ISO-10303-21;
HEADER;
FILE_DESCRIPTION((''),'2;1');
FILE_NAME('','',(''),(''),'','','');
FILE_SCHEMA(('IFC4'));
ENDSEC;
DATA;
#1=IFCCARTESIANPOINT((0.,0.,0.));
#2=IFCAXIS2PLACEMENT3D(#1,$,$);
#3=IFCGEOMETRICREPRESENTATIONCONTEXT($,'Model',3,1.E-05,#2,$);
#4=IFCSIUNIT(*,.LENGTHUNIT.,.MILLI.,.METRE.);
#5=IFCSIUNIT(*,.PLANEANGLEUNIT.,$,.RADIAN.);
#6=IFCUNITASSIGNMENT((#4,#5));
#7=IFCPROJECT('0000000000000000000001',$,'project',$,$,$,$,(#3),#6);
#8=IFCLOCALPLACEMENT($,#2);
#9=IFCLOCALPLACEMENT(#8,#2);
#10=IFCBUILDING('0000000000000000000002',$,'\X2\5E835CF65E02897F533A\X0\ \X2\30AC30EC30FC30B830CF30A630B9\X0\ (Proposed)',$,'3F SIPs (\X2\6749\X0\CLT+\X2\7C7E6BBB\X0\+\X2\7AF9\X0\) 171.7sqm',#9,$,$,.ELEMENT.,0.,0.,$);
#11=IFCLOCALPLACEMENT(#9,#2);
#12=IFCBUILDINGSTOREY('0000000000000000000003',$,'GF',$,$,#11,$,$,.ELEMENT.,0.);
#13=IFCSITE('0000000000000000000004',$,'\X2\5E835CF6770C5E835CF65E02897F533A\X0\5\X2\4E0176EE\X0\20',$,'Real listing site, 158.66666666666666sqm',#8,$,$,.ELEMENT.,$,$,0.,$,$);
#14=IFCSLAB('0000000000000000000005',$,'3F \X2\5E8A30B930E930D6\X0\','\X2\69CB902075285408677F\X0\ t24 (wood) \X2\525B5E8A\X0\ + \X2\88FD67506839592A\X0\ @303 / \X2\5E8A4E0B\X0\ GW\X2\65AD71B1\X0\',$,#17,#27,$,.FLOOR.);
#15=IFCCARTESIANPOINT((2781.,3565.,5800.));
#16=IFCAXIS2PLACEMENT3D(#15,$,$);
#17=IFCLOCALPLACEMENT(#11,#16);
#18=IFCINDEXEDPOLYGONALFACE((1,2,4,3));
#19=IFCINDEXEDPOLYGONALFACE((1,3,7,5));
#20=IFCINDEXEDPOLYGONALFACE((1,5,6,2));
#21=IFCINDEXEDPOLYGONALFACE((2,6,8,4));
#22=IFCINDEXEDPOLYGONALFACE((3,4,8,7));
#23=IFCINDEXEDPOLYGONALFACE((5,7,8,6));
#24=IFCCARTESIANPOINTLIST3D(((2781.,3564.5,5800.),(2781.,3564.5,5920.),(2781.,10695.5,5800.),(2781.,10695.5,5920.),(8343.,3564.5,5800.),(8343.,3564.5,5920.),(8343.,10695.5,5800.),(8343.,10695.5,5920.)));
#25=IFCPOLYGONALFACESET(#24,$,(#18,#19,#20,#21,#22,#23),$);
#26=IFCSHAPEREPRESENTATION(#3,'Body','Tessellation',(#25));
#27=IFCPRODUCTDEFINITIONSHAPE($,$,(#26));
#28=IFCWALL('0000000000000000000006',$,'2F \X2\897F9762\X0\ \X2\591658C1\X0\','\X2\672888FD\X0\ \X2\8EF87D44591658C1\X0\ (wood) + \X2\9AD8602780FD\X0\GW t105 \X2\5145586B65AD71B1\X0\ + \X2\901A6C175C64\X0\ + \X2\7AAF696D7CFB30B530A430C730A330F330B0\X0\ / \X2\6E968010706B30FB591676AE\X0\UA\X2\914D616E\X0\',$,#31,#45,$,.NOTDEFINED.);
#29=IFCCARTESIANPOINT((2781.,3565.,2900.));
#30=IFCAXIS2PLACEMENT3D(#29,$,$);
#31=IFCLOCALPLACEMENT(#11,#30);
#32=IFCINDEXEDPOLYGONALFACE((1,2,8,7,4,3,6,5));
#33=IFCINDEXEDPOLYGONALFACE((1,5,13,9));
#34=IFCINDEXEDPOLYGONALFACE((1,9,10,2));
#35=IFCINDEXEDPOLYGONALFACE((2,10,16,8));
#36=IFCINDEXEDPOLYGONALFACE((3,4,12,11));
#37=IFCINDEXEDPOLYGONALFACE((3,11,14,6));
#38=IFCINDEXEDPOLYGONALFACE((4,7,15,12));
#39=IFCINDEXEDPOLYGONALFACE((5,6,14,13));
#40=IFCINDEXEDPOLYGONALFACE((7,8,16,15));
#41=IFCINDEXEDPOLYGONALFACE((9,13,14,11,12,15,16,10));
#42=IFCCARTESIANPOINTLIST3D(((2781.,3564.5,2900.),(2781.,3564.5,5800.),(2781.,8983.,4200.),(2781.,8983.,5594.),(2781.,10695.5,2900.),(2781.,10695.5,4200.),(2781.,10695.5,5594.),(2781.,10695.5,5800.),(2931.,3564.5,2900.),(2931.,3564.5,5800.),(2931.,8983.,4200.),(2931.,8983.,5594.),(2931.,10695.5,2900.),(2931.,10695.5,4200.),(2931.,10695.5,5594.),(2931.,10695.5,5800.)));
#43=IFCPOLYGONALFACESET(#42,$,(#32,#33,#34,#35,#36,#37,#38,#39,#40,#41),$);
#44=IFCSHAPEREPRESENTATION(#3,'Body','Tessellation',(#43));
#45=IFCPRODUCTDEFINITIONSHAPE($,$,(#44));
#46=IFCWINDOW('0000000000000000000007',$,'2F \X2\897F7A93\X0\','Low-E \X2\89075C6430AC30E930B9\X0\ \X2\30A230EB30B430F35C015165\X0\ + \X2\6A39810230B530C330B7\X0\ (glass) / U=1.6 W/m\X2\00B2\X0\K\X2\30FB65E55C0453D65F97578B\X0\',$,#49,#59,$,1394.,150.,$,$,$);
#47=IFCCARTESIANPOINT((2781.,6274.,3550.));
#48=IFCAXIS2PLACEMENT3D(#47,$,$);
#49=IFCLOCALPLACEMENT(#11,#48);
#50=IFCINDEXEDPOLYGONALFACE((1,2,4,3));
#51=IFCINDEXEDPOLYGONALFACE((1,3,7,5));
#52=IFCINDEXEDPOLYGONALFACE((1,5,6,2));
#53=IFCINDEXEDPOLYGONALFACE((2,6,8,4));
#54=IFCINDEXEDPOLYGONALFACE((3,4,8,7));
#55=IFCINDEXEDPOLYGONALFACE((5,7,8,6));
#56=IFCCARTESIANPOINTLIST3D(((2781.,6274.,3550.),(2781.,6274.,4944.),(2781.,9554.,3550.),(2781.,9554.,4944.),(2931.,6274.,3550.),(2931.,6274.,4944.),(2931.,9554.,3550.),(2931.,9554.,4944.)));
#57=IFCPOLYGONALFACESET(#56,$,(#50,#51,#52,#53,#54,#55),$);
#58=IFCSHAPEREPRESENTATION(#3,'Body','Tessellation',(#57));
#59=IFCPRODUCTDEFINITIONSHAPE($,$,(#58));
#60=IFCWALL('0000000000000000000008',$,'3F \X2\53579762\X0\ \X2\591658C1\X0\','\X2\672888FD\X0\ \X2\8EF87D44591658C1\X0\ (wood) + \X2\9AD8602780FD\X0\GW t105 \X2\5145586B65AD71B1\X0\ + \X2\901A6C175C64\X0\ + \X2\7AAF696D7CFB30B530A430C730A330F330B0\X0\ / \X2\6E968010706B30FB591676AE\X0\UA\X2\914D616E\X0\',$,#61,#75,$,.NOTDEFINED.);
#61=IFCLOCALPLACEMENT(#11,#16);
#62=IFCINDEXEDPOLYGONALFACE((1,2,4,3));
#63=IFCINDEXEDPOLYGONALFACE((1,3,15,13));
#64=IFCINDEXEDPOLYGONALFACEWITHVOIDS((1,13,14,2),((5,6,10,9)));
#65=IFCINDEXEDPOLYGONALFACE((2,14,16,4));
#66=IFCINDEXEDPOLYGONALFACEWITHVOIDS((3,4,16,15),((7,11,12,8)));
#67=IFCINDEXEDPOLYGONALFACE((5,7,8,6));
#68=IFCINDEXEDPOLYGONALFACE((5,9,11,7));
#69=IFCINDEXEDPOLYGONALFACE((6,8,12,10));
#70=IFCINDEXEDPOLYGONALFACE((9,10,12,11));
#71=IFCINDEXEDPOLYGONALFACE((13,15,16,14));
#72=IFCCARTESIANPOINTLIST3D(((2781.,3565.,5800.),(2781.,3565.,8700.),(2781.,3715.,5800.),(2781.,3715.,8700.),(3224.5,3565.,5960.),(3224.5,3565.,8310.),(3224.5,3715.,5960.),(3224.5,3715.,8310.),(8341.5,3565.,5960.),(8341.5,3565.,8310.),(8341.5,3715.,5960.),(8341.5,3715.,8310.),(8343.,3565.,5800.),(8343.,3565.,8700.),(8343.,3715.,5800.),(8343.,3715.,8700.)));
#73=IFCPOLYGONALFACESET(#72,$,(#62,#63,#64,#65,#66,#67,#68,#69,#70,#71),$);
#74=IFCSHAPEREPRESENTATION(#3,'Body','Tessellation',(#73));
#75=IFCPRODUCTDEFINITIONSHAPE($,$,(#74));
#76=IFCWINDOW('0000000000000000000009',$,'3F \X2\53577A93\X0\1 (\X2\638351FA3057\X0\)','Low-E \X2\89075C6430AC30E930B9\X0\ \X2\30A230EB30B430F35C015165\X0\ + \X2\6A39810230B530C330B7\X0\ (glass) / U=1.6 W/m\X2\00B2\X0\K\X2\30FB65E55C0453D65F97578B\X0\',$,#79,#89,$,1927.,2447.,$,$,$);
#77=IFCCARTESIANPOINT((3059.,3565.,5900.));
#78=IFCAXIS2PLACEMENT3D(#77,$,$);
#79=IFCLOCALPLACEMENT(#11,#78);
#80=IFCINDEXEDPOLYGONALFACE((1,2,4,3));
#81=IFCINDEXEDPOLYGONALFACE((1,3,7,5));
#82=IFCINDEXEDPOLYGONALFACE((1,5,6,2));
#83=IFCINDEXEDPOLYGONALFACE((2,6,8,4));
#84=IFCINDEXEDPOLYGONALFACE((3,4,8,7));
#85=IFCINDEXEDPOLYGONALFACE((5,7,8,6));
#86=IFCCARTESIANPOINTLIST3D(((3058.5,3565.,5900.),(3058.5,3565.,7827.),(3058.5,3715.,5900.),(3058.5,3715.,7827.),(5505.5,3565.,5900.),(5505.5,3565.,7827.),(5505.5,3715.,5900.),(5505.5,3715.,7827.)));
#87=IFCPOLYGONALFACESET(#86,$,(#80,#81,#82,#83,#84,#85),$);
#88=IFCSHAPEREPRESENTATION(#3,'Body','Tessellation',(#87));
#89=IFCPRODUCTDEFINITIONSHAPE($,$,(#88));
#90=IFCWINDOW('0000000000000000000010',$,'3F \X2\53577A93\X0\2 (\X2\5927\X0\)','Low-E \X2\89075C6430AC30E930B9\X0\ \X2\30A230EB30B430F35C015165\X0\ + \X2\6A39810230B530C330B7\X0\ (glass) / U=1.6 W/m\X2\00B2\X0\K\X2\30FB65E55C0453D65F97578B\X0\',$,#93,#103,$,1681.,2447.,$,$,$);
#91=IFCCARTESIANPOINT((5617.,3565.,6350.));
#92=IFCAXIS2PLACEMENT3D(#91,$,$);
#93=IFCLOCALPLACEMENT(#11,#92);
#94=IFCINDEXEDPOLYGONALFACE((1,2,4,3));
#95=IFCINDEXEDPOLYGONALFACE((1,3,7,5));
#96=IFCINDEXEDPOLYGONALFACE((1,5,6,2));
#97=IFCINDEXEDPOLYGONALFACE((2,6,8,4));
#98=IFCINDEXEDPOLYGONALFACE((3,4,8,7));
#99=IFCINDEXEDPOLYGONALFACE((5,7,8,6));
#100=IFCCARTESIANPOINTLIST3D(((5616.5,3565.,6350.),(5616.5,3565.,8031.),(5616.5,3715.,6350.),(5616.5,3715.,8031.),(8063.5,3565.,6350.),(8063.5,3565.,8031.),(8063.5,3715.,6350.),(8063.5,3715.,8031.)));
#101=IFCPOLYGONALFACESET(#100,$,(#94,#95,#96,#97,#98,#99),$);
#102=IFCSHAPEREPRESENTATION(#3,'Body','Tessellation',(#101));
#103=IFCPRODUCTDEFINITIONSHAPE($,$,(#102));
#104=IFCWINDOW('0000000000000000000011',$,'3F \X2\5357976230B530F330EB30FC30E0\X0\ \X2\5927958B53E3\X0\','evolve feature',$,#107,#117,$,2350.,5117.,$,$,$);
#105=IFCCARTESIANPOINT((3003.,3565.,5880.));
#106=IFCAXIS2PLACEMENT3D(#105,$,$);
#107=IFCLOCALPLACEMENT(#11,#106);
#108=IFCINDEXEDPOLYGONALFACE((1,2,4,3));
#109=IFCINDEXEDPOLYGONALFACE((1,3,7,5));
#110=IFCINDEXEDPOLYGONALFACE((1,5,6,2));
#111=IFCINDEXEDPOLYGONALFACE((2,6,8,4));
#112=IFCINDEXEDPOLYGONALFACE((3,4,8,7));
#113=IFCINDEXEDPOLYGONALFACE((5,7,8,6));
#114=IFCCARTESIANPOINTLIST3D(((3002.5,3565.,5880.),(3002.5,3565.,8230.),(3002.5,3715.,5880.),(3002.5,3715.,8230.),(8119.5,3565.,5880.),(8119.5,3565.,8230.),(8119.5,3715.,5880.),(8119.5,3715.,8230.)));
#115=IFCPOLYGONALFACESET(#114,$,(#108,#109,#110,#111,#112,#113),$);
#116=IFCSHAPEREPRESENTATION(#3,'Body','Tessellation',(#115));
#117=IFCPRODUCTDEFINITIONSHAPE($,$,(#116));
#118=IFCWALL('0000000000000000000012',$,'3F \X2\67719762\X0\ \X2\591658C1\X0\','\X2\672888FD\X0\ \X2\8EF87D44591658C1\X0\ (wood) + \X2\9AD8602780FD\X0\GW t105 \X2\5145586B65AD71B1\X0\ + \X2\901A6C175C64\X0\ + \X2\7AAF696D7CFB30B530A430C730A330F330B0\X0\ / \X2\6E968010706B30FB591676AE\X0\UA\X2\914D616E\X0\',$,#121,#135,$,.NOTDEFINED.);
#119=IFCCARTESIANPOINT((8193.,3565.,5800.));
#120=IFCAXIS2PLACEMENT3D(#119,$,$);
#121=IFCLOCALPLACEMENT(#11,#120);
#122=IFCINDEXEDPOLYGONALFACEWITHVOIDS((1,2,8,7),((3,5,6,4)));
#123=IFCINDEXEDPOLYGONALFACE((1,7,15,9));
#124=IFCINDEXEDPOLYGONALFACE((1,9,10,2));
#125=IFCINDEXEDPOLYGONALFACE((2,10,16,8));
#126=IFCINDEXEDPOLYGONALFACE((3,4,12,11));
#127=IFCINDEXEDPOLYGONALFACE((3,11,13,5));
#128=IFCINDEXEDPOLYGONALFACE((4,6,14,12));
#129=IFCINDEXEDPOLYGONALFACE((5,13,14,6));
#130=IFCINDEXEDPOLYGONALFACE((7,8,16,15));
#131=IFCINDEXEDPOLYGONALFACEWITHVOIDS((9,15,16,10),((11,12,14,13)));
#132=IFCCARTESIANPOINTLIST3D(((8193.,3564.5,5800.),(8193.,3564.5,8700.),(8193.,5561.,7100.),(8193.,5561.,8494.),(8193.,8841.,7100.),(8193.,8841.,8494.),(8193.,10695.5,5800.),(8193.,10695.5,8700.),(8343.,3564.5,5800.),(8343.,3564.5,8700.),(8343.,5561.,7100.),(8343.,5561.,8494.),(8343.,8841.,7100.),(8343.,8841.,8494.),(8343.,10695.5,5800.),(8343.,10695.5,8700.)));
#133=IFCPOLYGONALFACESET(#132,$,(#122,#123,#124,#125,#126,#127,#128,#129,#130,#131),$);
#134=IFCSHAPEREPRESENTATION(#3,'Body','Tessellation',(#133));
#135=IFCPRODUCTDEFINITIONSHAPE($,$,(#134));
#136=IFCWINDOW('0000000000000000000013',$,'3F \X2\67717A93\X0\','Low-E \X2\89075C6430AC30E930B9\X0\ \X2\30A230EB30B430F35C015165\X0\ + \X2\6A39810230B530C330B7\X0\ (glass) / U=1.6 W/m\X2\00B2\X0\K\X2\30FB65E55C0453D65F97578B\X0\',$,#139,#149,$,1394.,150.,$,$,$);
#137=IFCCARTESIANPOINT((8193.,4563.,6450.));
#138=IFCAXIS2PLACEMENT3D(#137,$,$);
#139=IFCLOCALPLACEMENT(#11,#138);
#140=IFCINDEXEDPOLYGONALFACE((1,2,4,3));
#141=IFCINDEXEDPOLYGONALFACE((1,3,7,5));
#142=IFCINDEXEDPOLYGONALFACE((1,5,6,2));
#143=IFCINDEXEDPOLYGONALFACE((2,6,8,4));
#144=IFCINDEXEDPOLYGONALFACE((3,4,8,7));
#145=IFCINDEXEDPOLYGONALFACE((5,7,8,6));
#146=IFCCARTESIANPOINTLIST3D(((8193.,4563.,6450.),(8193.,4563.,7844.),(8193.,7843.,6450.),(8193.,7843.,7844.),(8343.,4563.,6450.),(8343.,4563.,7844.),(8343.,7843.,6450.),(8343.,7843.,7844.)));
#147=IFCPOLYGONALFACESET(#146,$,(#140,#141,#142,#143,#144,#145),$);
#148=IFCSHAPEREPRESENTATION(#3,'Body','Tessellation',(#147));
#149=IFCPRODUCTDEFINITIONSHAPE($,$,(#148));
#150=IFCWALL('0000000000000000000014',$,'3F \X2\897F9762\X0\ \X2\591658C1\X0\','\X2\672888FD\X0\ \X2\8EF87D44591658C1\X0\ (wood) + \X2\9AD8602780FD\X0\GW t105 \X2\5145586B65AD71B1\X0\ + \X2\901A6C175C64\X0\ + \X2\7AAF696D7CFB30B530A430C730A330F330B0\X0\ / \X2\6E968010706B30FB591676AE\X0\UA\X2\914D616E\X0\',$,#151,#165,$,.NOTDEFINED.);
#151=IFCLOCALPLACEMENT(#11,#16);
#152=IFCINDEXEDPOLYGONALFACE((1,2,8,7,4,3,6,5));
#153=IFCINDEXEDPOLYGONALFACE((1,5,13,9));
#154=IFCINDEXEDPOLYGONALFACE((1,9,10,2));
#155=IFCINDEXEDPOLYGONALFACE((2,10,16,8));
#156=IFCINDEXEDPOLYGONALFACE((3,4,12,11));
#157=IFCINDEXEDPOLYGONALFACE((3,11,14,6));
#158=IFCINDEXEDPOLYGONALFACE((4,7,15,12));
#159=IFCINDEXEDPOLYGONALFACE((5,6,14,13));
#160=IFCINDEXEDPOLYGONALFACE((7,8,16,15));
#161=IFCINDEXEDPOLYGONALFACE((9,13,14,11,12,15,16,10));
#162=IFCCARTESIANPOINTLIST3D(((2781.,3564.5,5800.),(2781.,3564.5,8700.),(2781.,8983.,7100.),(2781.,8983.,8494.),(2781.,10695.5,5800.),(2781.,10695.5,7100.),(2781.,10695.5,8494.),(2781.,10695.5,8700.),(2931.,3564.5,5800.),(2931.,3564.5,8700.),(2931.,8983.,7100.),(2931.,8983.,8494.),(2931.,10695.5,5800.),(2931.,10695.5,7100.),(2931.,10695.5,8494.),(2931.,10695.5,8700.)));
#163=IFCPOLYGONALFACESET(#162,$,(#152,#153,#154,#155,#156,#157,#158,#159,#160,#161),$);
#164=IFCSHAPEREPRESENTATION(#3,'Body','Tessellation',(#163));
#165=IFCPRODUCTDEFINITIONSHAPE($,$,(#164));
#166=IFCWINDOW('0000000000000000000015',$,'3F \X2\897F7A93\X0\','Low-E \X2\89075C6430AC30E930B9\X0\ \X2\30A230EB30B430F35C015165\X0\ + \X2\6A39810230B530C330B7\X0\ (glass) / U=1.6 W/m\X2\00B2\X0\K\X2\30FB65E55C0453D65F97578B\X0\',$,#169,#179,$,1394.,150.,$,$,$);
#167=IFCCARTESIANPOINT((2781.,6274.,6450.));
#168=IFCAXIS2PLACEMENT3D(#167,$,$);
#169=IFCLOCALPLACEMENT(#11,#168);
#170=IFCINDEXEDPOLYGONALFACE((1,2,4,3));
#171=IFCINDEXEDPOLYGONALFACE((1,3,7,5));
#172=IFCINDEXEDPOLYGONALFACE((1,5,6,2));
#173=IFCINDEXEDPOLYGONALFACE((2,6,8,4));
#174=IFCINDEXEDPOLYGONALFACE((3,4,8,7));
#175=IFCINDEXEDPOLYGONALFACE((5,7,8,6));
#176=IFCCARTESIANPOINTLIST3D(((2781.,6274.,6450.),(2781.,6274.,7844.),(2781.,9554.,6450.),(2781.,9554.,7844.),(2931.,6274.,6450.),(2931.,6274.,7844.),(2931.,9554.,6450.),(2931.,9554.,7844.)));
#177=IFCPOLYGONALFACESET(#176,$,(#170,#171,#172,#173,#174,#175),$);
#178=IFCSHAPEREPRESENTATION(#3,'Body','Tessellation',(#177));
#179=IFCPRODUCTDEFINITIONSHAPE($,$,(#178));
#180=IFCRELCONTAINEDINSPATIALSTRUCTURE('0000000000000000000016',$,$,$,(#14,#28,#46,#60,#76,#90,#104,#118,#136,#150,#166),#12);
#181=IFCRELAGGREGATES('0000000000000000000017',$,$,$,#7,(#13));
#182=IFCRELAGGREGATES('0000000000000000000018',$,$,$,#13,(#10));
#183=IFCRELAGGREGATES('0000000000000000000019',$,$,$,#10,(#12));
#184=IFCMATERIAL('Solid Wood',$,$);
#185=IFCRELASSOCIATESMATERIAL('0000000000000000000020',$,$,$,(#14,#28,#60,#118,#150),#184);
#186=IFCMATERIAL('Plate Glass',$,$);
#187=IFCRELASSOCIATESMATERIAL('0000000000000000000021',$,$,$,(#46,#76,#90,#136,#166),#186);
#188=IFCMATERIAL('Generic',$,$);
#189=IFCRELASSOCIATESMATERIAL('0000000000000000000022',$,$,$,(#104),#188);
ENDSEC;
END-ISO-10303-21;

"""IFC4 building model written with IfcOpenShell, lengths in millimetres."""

from ifc_helpers import new_model, si_unit, frame, frame_2d, origin, place, context, project, spatial, rectangle, extrude, material, element, fill, save


model = new_model("IFC4")

# Units and contexts
model_context = context("Model", 3, precision=1e-05, world=origin())
ifc_project = project(units=[si_unit("LENGTHUNIT", "METRE", prefix="MILLI"), si_unit("PLANEANGLEUNIT", "RADIAN")], contexts=[model_context])

# Site, building, storey
site_placement = place(None, origin())
site = spatial("IfcSite", under=ifc_project, at=site_placement, Name="広島県広島市西区5丁目20", ObjectType="Real listing site, 158.66666666666666sqm", CompositionType="ELEMENT", RefElevation=0.0)
building_placement = place(site_placement, origin())
building = spatial("IfcBuilding", under=site, at=building_placement, Name="広島市西区 ガレージハウス (Proposed)", ObjectType="3F SIPs (杉CLT+籾殻+竹) 171.7sqm", CompositionType="ELEMENT", ElevationOfRefHeight=0.0, ElevationOfTerrain=0.0)
storey_placement = place(building_placement, origin())
storey = spatial("IfcBuildingStorey", under=building, at=storey_placement, Name="GF", CompositionType="ELEMENT", Elevation=0.0)

# Slab
ifc_material_1 = material(Name="Solid Wood")
slab_placement = place(storey_placement, frame((2781.0, 3565.0, 5800.0)))
element("IfcSlab", 1, at=slab_placement, inside=storey, material=ifc_material_1, Name="3F 床スラブ", Description="構造用合板 t24 (wood) 剛床 + 製材根太 @303 / 床下 GW断熱", PredefinedType="FLOOR", context=model_context, shape_type="SweptSolid", body=[
    extrude(rectangle(XDim=5562.0, YDim=7131.0, at=frame_2d((2781.0, 3565.0))), frame((2781.0, 3565.0, 5800.0)), (0.0, 0.0, 1.0), 120.0),
])

# Wall, opening, window
wall_1_placement = place(storey_placement, frame((2781.0, 3565.0, 2900.0)))
wall_1 = element("IfcWall", 2, at=wall_1_placement, inside=storey, material=ifc_material_1, Name="2F 西面 外壁", Description="木製 軸組外壁 (wood) + 高性能GW t105 充填断熱 + 通気層 + 窯業系サイディング / 準耐火・外皮UA配慮", PredefinedType="NOTDEFINED", context=model_context, shape_type="SweptSolid", body=[
    extrude(rectangle(XDim=150.0, YDim=7131.0, at=frame_2d((75.0, 3565.0))), frame((2781.0, 3565.0, 2900.0)), (0.0, 0.0, 1.0), 2900.0),
])
opening_1_placement = place(storey_placement, frame((2781.0, 6274.0, 3550.0)))
opening_1 = element("IfcOpeningElement", 3, at=opening_1_placement, cuts=wall_1, PredefinedType="NOTDEFINED", context=model_context, shape_type="SweptSolid", body=[
    extrude(rectangle(XDim=150.0, YDim=3280.0, at=frame_2d((75.0, 1640.0))), frame((2781.0, 6274.0, 3550.0)), (0.0, 0.0, 1.0), 1394.0),
])
ifc_material_2 = material(Name="Plate Glass")
window_1_placement = place(storey_placement, frame((2781.0, 6274.0, 3550.0)))
window_1 = element("IfcWindow", 4, at=window_1_placement, inside=storey, material=ifc_material_2, Name="2F 西窓", Description="Low-E 複層ガラス アルゴン封入 + 樹脂サッシ (glass) / U=1.6 W/m²K・日射取得型", OverallHeight=1394.0, OverallWidth=150.0, context=model_context, shape_type="SweptSolid", body=[
    extrude(rectangle(XDim=150.0, YDim=3280.0, at=frame_2d((75.0, 1640.0))), frame((2781.0, 6274.0, 3550.0)), (0.0, 0.0, 1.0), 1394.0),
])
fill(opening_1, window_1)

# Wall, openings, windows
wall_2_placement = place(storey_placement, frame((2781.0, 3565.0, 5800.0)))
wall_2 = element("IfcWall", 5, at=wall_2_placement, inside=storey, material=ifc_material_1, Name="3F 南面 外壁", Description="木製 軸組外壁 (wood) + 高性能GW t105 充填断熱 + 通気層 + 窯業系サイディング / 準耐火・外皮UA配慮", PredefinedType="NOTDEFINED", context=model_context, shape_type="SweptSolid", body=[
    extrude(rectangle(XDim=5562.0, YDim=150.0, at=frame_2d((2781.0, 75.0))), frame((2781.0, 3565.0, 5800.0)), (0.0, 0.0, 1.0), 2900.0),
])
opening_2_placement = place(storey_placement, frame((3059.0, 3565.0, 5900.0)))
opening_2 = element("IfcOpeningElement", 6, at=opening_2_placement, cuts=wall_2, PredefinedType="NOTDEFINED", context=model_context, shape_type="SweptSolid", body=[
    extrude(rectangle(XDim=2447.0, YDim=150.0, at=frame_2d((1223.0, 75.0))), frame((3059.0, 3565.0, 5900.0)), (0.0, 0.0, 1.0), 1927.0),
])
opening_3_placement = place(storey_placement, frame((5617.0, 3565.0, 6350.0)))
opening_3 = element("IfcOpeningElement", 7, at=opening_3_placement, cuts=wall_2, PredefinedType="NOTDEFINED", context=model_context, shape_type="SweptSolid", body=[
    extrude(rectangle(XDim=2447.0, YDim=150.0, at=frame_2d((1223.0, 75.0))), frame((5617.0, 3565.0, 6350.0)), (0.0, 0.0, 1.0), 1681.0),
])
opening_4_placement = place(storey_placement, frame((3003.0, 3565.0, 5880.0)))
opening_4 = element("IfcOpeningElement", 8, at=opening_4_placement, cuts=wall_2, PredefinedType="NOTDEFINED", context=model_context, shape_type="SweptSolid", body=[
    extrude(rectangle(XDim=5117.0, YDim=150.0, at=frame_2d((2558.0, 75.0))), frame((3003.0, 3565.0, 5880.0)), (0.0, 0.0, 1.0), 2350.0),
])
window_2_placement = place(storey_placement, frame((3059.0, 3565.0, 5900.0)))
window_2 = element("IfcWindow", 9, at=window_2_placement, inside=storey, material=ifc_material_2, Name="3F 南窓1 (掃出し)", Description="Low-E 複層ガラス アルゴン封入 + 樹脂サッシ (glass) / U=1.6 W/m²K・日射取得型", OverallHeight=1927.0, OverallWidth=2447.0, context=model_context, shape_type="SweptSolid", body=[
    extrude(rectangle(XDim=2447.0, YDim=150.0, at=frame_2d((1223.0, 75.0))), frame((3059.0, 3565.0, 5900.0)), (0.0, 0.0, 1.0), 1927.0),
])
fill(opening_2, window_2)
window_3_placement = place(storey_placement, frame((5617.0, 3565.0, 6350.0)))
window_3 = element("IfcWindow", 10, at=window_3_placement, inside=storey, material=ifc_material_2, Name="3F 南窓2 (大)", Description="Low-E 複層ガラス アルゴン封入 + 樹脂サッシ (glass) / U=1.6 W/m²K・日射取得型", OverallHeight=1681.0, OverallWidth=2447.0, context=model_context, shape_type="SweptSolid", body=[
    extrude(rectangle(XDim=2447.0, YDim=150.0, at=frame_2d((1223.0, 75.0))), frame((5617.0, 3565.0, 6350.0)), (0.0, 0.0, 1.0), 1681.0),
])
fill(opening_3, window_3)
ifc_material_3 = material(Name="Generic")
window_4_placement = place(storey_placement, frame((3003.0, 3565.0, 5880.0)))
window_4 = element("IfcWindow", 11, at=window_4_placement, inside=storey, material=ifc_material_3, Name="3F 南面サンルーム 大開口", Description="evolve feature", OverallHeight=2350.0, OverallWidth=5117.0, context=model_context, shape_type="SweptSolid", body=[
    extrude(rectangle(XDim=5117.0, YDim=150.0, at=frame_2d((2558.0, 75.0))), frame((3003.0, 3565.0, 5880.0)), (0.0, 0.0, 1.0), 2350.0),
])
fill(opening_4, window_4)

# Walls, openings, windows
wall_3_placement = place(storey_placement, frame((8193.0, 3565.0, 5800.0)))
wall_3 = element("IfcWall", 12, at=wall_3_placement, inside=storey, material=ifc_material_1, Name="3F 東面 外壁", Description="木製 軸組外壁 (wood) + 高性能GW t105 充填断熱 + 通気層 + 窯業系サイディング / 準耐火・外皮UA配慮", PredefinedType="NOTDEFINED", context=model_context, shape_type="SweptSolid", body=[
    extrude(rectangle(XDim=150.0, YDim=7131.0, at=frame_2d((75.0, 3565.0))), frame((8193.0, 3565.0, 5800.0)), (0.0, 0.0, 1.0), 2900.0),
])
opening_5_placement = place(storey_placement, frame((8193.0, 4563.0, 6450.0)))
opening_5 = element("IfcOpeningElement", 13, at=opening_5_placement, cuts=wall_3, PredefinedType="NOTDEFINED", context=model_context, shape_type="SweptSolid", body=[
    extrude(rectangle(XDim=150.0, YDim=3280.0, at=frame_2d((75.0, 1640.0))), frame((8193.0, 4563.0, 6450.0)), (0.0, 0.0, 1.0), 1394.0),
])
window_5_placement = place(storey_placement, frame((8193.0, 4563.0, 6450.0)))
window_5 = element("IfcWindow", 14, at=window_5_placement, inside=storey, material=ifc_material_2, Name="3F 東窓", Description="Low-E 複層ガラス アルゴン封入 + 樹脂サッシ (glass) / U=1.6 W/m²K・日射取得型", OverallHeight=1394.0, OverallWidth=150.0, context=model_context, shape_type="SweptSolid", body=[
    extrude(rectangle(XDim=150.0, YDim=3280.0, at=frame_2d((75.0, 1640.0))), frame((8193.0, 4563.0, 6450.0)), (0.0, 0.0, 1.0), 1394.0),
])
fill(opening_5, window_5)
wall_4_placement = place(storey_placement, frame((2781.0, 3565.0, 5800.0)))
wall_4 = element("IfcWall", 15, at=wall_4_placement, inside=storey, material=ifc_material_1, Name="3F 西面 外壁", Description="木製 軸組外壁 (wood) + 高性能GW t105 充填断熱 + 通気層 + 窯業系サイディング / 準耐火・外皮UA配慮", PredefinedType="NOTDEFINED", context=model_context, shape_type="SweptSolid", body=[
    extrude(rectangle(XDim=150.0, YDim=7131.0, at=frame_2d((75.0, 3565.0))), frame((2781.0, 3565.0, 5800.0)), (0.0, 0.0, 1.0), 2900.0),
])
opening_6_placement = place(storey_placement, frame((2781.0, 6274.0, 6450.0)))
opening_6 = element("IfcOpeningElement", 16, at=opening_6_placement, cuts=wall_4, PredefinedType="NOTDEFINED", context=model_context, shape_type="SweptSolid", body=[
    extrude(rectangle(XDim=150.0, YDim=3280.0, at=frame_2d((75.0, 1640.0))), frame((2781.0, 6274.0, 6450.0)), (0.0, 0.0, 1.0), 1394.0),
])
window_6_placement = place(storey_placement, frame((2781.0, 6274.0, 6450.0)))
window_6 = element("IfcWindow", 17, at=window_6_placement, inside=storey, material=ifc_material_2, Name="3F 西窓", Description="Low-E 複層ガラス アルゴン封入 + 樹脂サッシ (glass) / U=1.6 W/m²K・日射取得型", OverallHeight=1394.0, OverallWidth=150.0, context=model_context, shape_type="SweptSolid", body=[
    extrude(rectangle(XDim=150.0, YDim=3280.0, at=frame_2d((75.0, 1640.0))), frame((2781.0, 6274.0, 6450.0)), (0.0, 0.0, 1.0), 1394.0),
])
fill(opening_6, window_6)

save(model, "model.ifc")
